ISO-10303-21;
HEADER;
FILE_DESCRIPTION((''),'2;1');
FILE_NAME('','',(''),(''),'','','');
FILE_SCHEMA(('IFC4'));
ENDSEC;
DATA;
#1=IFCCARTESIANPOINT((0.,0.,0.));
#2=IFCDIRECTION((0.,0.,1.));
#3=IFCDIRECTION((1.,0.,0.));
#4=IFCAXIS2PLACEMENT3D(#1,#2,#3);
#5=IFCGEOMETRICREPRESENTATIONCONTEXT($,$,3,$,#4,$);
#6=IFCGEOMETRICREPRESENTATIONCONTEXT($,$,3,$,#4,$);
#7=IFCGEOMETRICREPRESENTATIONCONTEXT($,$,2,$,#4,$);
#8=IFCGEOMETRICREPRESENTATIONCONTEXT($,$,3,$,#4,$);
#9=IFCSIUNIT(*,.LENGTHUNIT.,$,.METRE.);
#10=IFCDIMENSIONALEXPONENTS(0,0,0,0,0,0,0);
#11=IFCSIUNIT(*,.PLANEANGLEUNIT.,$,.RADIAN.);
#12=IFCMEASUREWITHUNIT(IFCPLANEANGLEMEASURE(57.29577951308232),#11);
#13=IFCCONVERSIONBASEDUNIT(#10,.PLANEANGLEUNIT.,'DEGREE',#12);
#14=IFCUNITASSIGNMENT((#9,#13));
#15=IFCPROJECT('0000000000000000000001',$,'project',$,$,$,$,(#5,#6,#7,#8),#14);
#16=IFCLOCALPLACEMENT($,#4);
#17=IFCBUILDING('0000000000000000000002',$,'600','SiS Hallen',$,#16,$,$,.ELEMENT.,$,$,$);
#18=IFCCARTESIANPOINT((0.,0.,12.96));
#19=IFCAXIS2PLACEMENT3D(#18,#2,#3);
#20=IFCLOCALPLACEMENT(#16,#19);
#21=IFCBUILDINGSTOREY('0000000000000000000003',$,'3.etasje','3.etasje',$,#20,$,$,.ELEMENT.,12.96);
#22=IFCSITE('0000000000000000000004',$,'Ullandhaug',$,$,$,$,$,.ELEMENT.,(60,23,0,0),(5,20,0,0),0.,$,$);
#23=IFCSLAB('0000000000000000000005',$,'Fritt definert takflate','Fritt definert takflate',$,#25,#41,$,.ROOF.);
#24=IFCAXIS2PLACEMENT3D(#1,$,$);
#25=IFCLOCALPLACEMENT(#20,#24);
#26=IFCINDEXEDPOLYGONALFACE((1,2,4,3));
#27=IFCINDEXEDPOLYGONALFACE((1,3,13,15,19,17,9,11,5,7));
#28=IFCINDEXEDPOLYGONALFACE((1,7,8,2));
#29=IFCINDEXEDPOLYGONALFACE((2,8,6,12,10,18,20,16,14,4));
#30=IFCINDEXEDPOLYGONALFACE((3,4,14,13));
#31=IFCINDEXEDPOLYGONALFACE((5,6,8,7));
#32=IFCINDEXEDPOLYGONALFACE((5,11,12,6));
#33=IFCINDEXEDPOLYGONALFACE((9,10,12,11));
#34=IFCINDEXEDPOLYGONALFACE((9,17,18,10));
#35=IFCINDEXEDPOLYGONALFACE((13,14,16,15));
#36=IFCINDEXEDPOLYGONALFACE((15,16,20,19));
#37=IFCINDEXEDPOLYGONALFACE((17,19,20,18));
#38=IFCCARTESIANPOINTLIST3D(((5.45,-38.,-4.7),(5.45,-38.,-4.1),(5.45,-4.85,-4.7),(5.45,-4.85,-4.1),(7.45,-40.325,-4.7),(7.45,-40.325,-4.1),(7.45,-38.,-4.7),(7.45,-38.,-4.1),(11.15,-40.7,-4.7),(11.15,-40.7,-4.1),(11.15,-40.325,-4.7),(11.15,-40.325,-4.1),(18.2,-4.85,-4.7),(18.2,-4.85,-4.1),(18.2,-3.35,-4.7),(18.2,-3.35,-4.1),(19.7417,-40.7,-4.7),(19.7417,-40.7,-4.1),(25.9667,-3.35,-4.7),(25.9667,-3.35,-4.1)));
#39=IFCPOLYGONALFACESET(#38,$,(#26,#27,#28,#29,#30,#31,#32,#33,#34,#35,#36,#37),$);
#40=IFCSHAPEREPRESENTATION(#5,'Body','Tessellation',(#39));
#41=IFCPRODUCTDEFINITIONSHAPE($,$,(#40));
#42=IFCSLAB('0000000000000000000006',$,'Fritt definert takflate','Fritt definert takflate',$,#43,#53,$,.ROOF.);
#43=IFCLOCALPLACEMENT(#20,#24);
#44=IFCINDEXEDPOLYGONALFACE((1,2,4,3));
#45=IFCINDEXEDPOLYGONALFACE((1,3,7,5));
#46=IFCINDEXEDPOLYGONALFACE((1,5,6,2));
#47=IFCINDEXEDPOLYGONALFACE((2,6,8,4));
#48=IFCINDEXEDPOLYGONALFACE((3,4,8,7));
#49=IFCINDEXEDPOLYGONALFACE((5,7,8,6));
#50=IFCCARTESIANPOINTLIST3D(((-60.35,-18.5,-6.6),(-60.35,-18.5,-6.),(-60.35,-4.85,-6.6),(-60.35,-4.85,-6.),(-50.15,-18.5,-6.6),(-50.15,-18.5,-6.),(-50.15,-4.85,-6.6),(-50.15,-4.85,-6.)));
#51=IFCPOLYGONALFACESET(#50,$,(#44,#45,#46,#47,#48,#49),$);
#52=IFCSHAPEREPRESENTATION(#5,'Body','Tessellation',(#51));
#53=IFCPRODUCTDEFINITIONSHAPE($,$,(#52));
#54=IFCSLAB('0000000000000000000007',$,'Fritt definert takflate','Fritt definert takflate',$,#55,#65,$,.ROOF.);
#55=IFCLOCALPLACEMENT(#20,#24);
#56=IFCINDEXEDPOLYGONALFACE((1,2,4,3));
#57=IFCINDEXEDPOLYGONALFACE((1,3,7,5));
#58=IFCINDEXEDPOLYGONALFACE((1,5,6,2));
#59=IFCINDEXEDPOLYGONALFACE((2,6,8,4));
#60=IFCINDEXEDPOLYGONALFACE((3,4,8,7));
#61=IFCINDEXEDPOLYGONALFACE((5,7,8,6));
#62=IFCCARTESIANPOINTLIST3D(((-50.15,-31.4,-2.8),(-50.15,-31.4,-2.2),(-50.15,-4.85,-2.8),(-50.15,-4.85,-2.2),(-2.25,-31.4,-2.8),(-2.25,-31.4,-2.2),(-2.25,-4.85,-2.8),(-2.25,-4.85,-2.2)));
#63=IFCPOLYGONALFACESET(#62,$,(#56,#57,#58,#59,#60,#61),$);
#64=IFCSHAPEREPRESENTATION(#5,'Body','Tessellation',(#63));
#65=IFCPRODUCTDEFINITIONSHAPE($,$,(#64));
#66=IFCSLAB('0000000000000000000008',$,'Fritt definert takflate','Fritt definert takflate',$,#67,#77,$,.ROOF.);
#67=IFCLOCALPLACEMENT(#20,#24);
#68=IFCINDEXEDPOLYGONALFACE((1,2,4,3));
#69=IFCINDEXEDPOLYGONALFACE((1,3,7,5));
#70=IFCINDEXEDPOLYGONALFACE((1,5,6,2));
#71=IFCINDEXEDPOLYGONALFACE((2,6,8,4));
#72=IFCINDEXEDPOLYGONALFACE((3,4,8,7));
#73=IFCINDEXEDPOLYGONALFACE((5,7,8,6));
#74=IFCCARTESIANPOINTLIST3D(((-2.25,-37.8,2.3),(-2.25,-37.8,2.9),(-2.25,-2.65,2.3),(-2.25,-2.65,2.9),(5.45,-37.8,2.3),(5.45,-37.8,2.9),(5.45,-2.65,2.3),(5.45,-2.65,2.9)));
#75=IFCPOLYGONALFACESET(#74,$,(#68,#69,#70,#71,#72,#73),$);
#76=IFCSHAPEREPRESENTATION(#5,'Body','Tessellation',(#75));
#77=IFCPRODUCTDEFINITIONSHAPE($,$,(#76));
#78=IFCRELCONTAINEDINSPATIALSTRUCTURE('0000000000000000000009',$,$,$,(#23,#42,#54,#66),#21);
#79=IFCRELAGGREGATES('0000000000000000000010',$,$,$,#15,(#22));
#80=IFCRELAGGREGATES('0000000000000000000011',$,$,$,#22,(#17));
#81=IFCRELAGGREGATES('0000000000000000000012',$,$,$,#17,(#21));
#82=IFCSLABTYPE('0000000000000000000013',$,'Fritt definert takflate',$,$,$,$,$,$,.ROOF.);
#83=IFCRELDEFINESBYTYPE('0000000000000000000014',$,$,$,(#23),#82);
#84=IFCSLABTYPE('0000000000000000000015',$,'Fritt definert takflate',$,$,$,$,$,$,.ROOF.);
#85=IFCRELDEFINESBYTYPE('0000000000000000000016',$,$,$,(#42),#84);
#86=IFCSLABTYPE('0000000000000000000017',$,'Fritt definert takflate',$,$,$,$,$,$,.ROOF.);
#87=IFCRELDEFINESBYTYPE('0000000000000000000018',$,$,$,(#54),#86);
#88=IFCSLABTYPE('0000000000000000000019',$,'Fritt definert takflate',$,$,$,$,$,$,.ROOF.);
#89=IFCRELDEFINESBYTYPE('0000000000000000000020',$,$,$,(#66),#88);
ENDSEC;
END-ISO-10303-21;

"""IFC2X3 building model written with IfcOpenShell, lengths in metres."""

from ifc_helpers import new_model, entity, si_unit, converted_unit, frame, origin_with_axes, place, context, project, spatial, polyline, outline, extrude, type_object, element, save


model = new_model("IFC2X3")

# Units and contexts
context_of_model_1 = context(None, 3, world=origin_with_axes())
context_of_model_2 = context(None, 3, world=origin_with_axes())
context_of_model_3 = context(None, 2, world=origin_with_axes())
context_of_model_4 = context(None, 3, world=origin_with_axes())
ifc_project = project(units=[si_unit("LENGTHUNIT", "METRE"), converted_unit("PLANEANGLEUNIT", "DEGREE", entity("IfcPlaneAngleMeasure", 57.29577951308232), si_unit("PLANEANGLEUNIT", "RADIAN"), dimensions=[0, 0, 0, 0, 0, 0, 0])], contexts=[context_of_model_1, context_of_model_2, context_of_model_3, context_of_model_4])

# Site, building, storey
site = spatial("IfcSite", under=ifc_project, Name="Ullandhaug", CompositionType="ELEMENT", RefLatitude=(60, 23, 0, 0), RefLongitude=(5, 20, 0, 0), RefElevation=0.0)
building_placement = place(None, origin_with_axes())
building = spatial("IfcBuilding", under=site, at=building_placement, Name="600", Description="SiS Hallen", CompositionType="ELEMENT")
storey_placement = place(building_placement, frame((0.0, 0.0, 12.96), z_axis=(0.0, 0.0, 1.0), x_axis=(1.0, 0.0, 0.0)))
storey = spatial("IfcBuildingStorey", under=building, at=storey_placement, Name="3.etasje", Description="3.etasje", CompositionType="ELEMENT", Elevation=12.96)

# Slabs
slab_type_1 = type_object("IfcSlabType", Name="Fritt definert takflate", PredefinedType="ROOF")
slab_1_placement = place(storey_placement, frame((11.15, -40.325, -4.7), z_axis=(0.0, 0.0, 1.0), x_axis=(0.0, -1.0, 0.0)))
element("IfcSlab", 1, at=slab_1_placement, inside=storey, type_object=slab_type_1, Name="Fritt definert takflate", Description="Fritt definert takflate", PredefinedType="ROOF", context=context_of_model_1, shape_type="SweptSolid", body=[
    extrude(outline(polyline([(0.0, 0.0), (0.375, 0.0), (0.375, 8.5917), (-36.975, 14.8167), (-36.975, 7.05), (-35.475, 7.05), (-35.475, -5.7), (-2.325, -5.7), (-2.325, -3.7), (0.0, -3.7), (0.0, 0.0)])), origin_with_axes(), (0.0, 0.0, 1.0), 0.6),
])
slab_type_2 = type_object("IfcSlabType", Name="Fritt definert takflate", PredefinedType="ROOF")
slab_2_placement = place(storey_placement, frame((-60.35, -18.5, -6.6), z_axis=(0.0, 0.0, 1.0), x_axis=(1.0, 0.0, 0.0)))
element("IfcSlab", 2, at=slab_2_placement, inside=storey, type_object=slab_type_2, Name="Fritt definert takflate", Description="Fritt definert takflate", PredefinedType="ROOF", context=context_of_model_1, shape_type="SweptSolid", body=[
    extrude(outline(polyline([(0.0, 0.0), (10.2, 0.0), (10.2, 13.65), (0.0, 13.65), (0.0, 0.0)])), origin_with_axes(), (0.0, 0.0, 1.0), 0.6),
])
slab_type_3 = type_object("IfcSlabType", Name="Fritt definert takflate", PredefinedType="ROOF")
slab_3_placement = place(storey_placement, frame((-50.15, -31.4, -2.8), z_axis=(0.0, 0.0, 1.0), x_axis=(1.0, 0.0, 0.0)))
element("IfcSlab", 3, at=slab_3_placement, inside=storey, type_object=slab_type_3, Name="Fritt definert takflate", Description="Fritt definert takflate", PredefinedType="ROOF", context=context_of_model_1, shape_type="SweptSolid", body=[
    extrude(outline(polyline([(0.0, 0.0), (47.9, 0.0), (47.9, 26.55), (0.0, 26.55), (0.0, 0.0)])), origin_with_axes(), (0.0, 0.0, 1.0), 0.6),
])
slab_type_4 = type_object("IfcSlabType", Name="Fritt definert takflate", PredefinedType="ROOF")
slab_4_placement = place(storey_placement, frame((5.45, -2.65, 2.3), z_axis=(0.0, 0.0, 1.0), x_axis=(-1.0, 0.0, 0.0)))
element("IfcSlab", 4, at=slab_4_placement, inside=storey, type_object=slab_type_4, Name="Fritt definert takflate", Description="Fritt definert takflate", PredefinedType="ROOF", context=context_of_model_1, shape_type="SweptSolid", body=[
    extrude(outline(polyline([(0.0, 0.0), (7.7, 0.0), (7.7, 35.15), (0.0, 35.15), (0.0, 0.0)])), origin_with_axes(), (0.0, 0.0, 1.0), 0.6),
])

save(model, "model.ifc")
